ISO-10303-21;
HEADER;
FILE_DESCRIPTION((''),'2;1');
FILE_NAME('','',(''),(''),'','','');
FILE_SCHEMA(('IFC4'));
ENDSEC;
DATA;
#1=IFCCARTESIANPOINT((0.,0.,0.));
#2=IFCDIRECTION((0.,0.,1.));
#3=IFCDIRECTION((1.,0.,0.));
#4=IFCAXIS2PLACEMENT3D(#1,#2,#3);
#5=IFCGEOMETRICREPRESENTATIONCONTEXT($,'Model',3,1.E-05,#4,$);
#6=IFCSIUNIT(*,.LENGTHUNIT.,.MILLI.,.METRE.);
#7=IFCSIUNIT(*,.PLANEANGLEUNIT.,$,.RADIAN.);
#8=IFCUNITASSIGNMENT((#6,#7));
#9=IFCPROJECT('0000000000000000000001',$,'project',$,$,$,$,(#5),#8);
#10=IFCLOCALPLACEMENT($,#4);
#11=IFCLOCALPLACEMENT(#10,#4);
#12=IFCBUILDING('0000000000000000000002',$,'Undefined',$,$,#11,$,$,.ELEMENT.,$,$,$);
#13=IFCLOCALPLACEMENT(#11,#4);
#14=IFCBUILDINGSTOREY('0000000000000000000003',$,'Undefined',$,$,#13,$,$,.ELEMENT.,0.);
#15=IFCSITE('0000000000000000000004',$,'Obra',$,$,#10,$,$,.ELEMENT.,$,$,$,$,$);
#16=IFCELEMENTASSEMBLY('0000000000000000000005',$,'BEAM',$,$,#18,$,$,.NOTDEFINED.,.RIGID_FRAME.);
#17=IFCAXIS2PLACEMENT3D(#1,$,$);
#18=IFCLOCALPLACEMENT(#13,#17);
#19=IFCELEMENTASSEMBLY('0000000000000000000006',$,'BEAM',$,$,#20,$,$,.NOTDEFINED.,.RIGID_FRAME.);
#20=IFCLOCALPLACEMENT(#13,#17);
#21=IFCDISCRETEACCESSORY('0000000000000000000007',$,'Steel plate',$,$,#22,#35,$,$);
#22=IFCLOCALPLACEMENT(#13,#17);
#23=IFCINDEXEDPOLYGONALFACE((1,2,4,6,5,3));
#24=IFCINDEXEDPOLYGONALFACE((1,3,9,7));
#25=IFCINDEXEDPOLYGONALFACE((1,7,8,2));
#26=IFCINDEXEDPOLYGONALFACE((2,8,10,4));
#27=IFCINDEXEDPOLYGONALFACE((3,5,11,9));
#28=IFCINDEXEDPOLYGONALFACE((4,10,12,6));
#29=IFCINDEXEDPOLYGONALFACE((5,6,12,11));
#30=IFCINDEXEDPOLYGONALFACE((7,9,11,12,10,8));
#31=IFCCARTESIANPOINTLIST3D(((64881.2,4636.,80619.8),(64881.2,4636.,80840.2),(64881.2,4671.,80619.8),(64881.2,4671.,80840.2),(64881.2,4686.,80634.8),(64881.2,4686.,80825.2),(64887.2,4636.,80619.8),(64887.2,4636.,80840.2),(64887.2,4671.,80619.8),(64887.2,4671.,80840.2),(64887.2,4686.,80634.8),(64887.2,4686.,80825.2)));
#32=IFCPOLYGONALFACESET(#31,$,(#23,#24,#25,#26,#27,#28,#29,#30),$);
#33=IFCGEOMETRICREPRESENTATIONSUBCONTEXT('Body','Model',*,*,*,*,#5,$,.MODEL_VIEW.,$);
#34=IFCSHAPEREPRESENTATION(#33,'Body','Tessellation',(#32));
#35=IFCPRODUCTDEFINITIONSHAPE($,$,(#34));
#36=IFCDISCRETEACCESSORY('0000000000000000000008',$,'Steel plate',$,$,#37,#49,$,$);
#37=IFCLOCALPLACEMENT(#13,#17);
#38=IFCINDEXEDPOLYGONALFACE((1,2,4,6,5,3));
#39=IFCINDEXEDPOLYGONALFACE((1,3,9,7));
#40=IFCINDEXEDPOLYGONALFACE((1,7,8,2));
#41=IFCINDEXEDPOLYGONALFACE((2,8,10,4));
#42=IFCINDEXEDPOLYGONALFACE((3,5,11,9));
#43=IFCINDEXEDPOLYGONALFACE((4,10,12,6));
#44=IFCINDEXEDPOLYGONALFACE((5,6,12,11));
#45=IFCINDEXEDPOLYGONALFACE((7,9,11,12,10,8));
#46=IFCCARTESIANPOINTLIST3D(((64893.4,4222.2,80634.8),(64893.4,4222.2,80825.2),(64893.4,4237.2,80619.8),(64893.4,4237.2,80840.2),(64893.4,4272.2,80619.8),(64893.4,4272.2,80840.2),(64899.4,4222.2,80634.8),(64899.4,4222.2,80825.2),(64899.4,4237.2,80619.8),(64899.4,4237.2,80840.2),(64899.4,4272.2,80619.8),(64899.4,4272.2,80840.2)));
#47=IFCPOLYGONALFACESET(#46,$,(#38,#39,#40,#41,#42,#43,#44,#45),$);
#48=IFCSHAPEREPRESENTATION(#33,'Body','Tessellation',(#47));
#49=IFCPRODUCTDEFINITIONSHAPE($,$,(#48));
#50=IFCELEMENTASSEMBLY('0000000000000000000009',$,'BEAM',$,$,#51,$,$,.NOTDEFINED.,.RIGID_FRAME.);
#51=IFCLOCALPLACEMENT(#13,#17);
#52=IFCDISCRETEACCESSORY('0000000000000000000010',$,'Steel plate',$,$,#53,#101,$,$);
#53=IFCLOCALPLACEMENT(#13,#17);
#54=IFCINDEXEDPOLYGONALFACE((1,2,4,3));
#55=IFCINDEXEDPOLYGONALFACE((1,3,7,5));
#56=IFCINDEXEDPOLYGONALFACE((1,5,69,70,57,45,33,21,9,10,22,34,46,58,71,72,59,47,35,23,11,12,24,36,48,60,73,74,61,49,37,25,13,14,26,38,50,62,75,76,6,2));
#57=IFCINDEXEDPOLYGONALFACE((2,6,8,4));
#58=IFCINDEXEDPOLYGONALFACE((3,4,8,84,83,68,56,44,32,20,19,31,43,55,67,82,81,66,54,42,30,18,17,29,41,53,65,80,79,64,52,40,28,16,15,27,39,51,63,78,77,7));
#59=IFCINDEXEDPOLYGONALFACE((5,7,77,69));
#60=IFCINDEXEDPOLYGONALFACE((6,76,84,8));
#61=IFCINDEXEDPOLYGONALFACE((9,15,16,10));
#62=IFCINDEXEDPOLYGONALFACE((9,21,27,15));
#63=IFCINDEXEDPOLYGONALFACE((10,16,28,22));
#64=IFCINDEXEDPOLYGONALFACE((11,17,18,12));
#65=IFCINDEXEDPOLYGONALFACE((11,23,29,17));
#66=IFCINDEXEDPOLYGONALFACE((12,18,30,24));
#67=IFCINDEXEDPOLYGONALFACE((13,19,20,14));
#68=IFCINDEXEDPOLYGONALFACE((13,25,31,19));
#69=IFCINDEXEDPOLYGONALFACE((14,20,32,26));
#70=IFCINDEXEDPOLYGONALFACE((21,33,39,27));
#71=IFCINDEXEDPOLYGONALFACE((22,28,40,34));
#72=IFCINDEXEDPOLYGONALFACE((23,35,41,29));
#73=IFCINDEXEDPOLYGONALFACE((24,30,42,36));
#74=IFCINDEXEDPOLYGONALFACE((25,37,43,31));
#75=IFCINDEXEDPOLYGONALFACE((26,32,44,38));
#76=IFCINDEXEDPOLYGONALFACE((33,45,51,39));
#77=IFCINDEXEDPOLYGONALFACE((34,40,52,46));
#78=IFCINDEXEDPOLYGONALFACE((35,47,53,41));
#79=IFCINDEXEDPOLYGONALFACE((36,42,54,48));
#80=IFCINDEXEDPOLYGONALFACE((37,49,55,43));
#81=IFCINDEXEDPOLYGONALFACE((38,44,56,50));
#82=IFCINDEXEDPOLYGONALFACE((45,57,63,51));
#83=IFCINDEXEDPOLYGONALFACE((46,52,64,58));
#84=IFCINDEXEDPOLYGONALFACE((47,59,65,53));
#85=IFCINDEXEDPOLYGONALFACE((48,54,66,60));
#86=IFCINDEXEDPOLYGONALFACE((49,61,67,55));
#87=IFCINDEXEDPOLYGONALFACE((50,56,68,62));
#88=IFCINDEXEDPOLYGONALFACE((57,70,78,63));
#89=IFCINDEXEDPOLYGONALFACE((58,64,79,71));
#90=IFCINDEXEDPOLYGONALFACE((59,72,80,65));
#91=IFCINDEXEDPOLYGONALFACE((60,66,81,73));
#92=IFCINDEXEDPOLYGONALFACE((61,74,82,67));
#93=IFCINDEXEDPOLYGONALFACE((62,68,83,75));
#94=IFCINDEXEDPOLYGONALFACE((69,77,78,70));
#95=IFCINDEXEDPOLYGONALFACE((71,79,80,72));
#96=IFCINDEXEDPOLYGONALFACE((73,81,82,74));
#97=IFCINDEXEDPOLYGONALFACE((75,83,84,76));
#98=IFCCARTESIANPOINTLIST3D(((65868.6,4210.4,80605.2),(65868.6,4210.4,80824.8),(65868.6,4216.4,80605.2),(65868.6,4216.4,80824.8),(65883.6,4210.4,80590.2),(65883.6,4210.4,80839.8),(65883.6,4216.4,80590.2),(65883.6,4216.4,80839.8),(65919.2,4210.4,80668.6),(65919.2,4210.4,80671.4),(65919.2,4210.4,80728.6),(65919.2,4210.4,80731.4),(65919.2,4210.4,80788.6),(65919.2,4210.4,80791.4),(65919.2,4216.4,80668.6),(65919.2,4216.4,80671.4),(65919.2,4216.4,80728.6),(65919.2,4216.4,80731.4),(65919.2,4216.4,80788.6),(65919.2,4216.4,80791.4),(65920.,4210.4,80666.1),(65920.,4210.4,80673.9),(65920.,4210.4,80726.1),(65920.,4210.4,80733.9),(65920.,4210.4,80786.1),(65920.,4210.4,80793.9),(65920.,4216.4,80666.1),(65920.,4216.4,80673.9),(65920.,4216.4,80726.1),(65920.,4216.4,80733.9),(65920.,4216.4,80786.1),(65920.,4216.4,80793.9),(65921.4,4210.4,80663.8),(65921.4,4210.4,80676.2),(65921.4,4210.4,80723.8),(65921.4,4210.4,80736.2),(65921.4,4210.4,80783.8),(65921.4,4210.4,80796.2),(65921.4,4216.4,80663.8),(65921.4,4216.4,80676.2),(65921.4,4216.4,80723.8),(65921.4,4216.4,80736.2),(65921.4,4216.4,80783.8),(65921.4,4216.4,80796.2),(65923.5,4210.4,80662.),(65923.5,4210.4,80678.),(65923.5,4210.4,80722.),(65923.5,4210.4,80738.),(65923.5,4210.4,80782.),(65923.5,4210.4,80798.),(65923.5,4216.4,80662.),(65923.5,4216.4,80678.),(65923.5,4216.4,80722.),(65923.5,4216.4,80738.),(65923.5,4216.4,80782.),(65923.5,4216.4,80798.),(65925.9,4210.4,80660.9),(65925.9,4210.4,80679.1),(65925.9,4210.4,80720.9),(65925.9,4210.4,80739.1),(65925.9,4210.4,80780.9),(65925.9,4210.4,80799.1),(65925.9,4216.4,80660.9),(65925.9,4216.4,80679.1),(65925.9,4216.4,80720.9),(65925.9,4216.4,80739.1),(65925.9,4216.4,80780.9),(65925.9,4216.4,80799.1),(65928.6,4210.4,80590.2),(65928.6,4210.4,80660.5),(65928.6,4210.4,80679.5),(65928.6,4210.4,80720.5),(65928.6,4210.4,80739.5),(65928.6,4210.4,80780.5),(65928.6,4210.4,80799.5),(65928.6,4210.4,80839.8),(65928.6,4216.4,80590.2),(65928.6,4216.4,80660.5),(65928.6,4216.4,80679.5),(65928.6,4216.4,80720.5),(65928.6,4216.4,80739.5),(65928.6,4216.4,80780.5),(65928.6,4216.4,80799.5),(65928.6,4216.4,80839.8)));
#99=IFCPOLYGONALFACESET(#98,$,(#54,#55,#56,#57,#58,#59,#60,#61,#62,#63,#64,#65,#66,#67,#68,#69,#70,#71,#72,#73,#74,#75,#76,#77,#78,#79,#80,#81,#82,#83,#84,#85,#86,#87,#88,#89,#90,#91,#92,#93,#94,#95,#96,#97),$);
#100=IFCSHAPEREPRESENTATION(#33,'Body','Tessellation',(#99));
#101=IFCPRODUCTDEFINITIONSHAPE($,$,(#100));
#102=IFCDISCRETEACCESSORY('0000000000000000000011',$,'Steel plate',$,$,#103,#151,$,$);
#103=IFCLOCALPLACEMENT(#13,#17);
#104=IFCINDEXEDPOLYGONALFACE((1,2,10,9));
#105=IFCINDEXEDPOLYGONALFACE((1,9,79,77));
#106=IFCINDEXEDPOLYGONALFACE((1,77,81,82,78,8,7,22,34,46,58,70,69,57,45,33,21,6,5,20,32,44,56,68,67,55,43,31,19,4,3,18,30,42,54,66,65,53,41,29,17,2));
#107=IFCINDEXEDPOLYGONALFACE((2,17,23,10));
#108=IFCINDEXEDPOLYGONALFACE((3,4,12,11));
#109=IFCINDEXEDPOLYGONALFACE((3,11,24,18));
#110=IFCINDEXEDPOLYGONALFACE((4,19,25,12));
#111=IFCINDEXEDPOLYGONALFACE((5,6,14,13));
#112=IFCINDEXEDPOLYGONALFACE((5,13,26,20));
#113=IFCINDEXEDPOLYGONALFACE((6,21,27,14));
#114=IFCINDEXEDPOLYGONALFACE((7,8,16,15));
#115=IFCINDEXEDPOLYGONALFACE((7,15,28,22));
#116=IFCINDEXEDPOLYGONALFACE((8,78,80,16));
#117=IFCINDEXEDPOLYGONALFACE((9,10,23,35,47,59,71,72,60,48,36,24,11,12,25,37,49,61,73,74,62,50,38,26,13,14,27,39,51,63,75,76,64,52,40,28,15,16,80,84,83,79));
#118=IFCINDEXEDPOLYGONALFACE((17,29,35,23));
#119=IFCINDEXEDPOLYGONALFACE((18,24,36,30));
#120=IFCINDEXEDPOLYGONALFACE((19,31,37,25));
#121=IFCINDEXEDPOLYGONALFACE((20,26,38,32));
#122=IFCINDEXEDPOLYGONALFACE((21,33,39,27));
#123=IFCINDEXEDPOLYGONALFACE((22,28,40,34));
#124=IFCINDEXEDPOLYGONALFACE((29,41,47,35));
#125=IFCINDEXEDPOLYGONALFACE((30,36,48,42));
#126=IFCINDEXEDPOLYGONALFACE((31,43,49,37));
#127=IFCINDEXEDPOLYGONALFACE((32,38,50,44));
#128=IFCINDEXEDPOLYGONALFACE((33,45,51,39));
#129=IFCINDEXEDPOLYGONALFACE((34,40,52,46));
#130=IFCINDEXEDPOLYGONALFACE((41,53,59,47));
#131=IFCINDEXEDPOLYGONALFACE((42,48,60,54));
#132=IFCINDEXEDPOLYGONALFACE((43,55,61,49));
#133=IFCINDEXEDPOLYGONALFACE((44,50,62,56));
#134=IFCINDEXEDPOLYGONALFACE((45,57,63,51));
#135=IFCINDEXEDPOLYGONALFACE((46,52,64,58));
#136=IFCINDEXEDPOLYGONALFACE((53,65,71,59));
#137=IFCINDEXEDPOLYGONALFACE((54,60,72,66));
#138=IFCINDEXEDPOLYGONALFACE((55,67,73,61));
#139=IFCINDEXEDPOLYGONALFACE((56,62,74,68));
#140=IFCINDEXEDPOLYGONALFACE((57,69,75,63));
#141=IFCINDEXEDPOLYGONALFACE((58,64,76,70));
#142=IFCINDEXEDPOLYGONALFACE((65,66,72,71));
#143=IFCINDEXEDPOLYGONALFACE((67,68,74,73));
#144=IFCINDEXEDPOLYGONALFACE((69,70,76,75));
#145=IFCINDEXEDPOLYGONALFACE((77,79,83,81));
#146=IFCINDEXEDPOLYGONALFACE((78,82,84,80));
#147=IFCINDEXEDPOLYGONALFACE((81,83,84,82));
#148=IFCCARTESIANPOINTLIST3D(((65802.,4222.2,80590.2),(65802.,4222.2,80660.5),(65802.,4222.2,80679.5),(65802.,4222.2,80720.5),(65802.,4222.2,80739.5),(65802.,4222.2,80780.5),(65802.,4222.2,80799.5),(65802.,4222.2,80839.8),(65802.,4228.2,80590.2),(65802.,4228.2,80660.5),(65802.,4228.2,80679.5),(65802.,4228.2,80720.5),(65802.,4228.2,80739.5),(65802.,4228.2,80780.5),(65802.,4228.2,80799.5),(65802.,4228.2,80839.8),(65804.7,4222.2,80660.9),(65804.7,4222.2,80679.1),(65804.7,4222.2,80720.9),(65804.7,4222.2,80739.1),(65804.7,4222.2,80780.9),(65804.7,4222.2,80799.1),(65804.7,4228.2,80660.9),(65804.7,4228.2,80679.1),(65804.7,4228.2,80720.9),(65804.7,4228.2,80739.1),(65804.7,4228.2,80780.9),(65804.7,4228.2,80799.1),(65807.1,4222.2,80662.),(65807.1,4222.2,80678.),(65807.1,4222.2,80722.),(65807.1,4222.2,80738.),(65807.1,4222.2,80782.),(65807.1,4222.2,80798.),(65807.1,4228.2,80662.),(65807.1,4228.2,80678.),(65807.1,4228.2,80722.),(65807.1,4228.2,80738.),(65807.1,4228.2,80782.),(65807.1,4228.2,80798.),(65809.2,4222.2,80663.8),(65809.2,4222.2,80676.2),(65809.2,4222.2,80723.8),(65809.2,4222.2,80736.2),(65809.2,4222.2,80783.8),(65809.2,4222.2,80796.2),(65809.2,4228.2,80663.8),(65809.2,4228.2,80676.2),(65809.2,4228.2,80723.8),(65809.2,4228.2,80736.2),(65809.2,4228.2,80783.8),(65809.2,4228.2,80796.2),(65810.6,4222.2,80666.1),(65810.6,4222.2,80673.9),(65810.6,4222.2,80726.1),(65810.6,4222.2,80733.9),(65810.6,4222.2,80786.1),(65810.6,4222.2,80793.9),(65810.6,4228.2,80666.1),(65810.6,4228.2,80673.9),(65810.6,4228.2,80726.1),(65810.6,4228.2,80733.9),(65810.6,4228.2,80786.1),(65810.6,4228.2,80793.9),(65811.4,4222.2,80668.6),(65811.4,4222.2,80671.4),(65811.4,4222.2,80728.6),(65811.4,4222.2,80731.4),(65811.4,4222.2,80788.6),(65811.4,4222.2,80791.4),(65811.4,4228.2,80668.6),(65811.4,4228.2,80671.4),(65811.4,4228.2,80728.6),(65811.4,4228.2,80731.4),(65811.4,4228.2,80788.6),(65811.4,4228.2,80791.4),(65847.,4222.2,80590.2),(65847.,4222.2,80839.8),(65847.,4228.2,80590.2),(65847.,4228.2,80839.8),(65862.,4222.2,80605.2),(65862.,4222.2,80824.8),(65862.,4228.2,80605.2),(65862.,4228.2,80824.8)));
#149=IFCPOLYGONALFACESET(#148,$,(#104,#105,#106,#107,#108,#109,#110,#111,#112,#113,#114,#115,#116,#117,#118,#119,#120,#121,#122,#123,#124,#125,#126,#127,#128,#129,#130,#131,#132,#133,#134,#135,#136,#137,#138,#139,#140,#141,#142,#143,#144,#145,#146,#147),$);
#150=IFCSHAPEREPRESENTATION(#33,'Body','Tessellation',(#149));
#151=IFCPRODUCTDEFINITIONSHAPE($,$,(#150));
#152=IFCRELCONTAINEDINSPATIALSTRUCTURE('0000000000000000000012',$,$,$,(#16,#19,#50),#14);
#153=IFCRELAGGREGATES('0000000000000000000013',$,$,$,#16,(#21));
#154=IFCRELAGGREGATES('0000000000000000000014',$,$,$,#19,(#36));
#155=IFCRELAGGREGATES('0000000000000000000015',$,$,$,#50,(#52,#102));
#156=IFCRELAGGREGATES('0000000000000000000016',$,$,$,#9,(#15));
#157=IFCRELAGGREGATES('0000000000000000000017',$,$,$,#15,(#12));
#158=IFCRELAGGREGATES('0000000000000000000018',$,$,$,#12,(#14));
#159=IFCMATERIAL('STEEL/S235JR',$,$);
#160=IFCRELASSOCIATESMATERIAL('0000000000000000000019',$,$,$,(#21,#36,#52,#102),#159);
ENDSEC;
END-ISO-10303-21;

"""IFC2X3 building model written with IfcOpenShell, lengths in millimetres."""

from ifc_helpers import new_model, si_unit, frame, origin_with_axes, origin_2d_with_axis, place, context, subcontext, project, spatial, polyline, circle, outline, extrude, source, transform, mapped, material, element, aggregate, save


model = new_model("IFC2X3")

# Units and contexts
model_context = context("Model", 3, precision=1e-05, world=origin_with_axes())
body_context = subcontext(model_context, "Body", "Model", "MODEL_VIEW")
ifc_project = project(units=[si_unit("LENGTHUNIT", "METRE", prefix="MILLI"), si_unit("PLANEANGLEUNIT", "RADIAN")], contexts=[model_context])

# Site, building, storey
site_placement = place(None, origin_with_axes())
site = spatial("IfcSite", under=ifc_project, at=site_placement, Name="Obra", CompositionType="ELEMENT")
building_placement = place(site_placement, origin_with_axes())
building = spatial("IfcBuilding", under=site, at=building_placement, Name="Undefined", CompositionType="ELEMENT")
storey_placement = place(building_placement, origin_with_axes())
storey = spatial("IfcBuildingStorey", under=building, at=storey_placement, Name="Undefined", CompositionType="ELEMENT", Elevation=0.0)

# Element assemblies
ifc_material = material(Name="STEEL/S235JR")
assembly_1_placement = place(storey_placement, origin_with_axes())
assembly_1 = element("IfcElementAssembly", 1, at=assembly_1_placement, inside=storey, Name="BEAM", AssemblyPlace="NOTDEFINED", PredefinedType="RIGID_FRAME")
assembly_2_placement = place(storey_placement, origin_with_axes())
assembly_2 = element("IfcElementAssembly", 2, at=assembly_2_placement, inside=storey, Name="BEAM", AssemblyPlace="NOTDEFINED", PredefinedType="RIGID_FRAME")

# Discrete accessories
discrete_accessory_1_placement = place(assembly_1_placement, frame((64884.2, 4636.0, 80619.8), z_axis=(1.0, 0.0, 0.0), x_axis=(0.0, 1.0, 0.0)))
discrete_accessory_1 = element("IfcDiscreteAccessory", 3, at=discrete_accessory_1_placement, material=ifc_material, Name="Steel plate", context=body_context, shape_type="SweptSolid", body=[
    extrude(outline(polyline([(0.0, 0.0), (35.0, 0.0), (50.0, 15.0), (50.0, 205.4), (35.0, 220.4), (0.0, 220.4), (0.0, 0.0)])), frame((0.0, 0.0, -3.0), z_axis=(0.0, 0.0, 1.0), x_axis=(1.0, 0.0, 0.0)), (0.0, 0.0, 1.0), 6.0),
])
aggregate(assembly_1, [discrete_accessory_1])
discrete_accessory_2_placement = place(assembly_2_placement, frame((64896.4, 4272.2, 80619.8), z_axis=(-1.0, 0.0, 0.0), x_axis=(0.0, -1.0, 0.0)))
discrete_accessory_2 = element("IfcDiscreteAccessory", 4, at=discrete_accessory_2_placement, material=ifc_material, Name="Steel plate", context=body_context, shape_type="SweptSolid", body=[
    extrude(outline(polyline([(0.0, 0.0), (35.0, 0.0), (50.0, 15.0), (50.0, 205.4), (35.0, 220.4), (0.0, 220.4), (0.0, 0.0)])), frame((0.0, 0.0, -3.0), z_axis=(0.0, 0.0, 1.0), x_axis=(1.0, 0.0, 0.0)), (0.0, 0.0, 1.0), 6.0),
])
aggregate(assembly_2, [discrete_accessory_2])

# Element assembly, discrete accessories, openings
assembly_3_placement = place(storey_placement, origin_with_axes())
assembly_3 = element("IfcElementAssembly", 5, at=assembly_3_placement, inside=storey, Name="BEAM", AssemblyPlace="NOTDEFINED", PredefinedType="RIGID_FRAME")
discrete_accessory_3_placement = place(assembly_3_placement, frame((65928.6, 4213.4, 80590.2), z_axis=(0.0, 1.0, 0.0), x_axis=(-1.0, 0.0, 0.0)))
discrete_accessory_3 = element("IfcDiscreteAccessory", 6, at=discrete_accessory_3_placement, material=ifc_material, Name="Steel plate", context=body_context, shape_type="SweptSolid", body=[
    extrude(outline(polyline([(0.0, 0.0), (45.0, 0.0), (60.0, 15.0), (60.0, 234.6), (45.0, 249.6), (0.0, 249.6), (0.0, 0.0)])), frame((0.0, 0.0, -3.0), z_axis=(0.0, 0.0, 1.0), x_axis=(1.0, 0.0, 0.0)), (0.0, 0.0, 1.0), 6.0),
])
shared_shape_1 = source(origin_with_axes(), body_context, "Body", "SweptSolid", [
    extrude(circle(Radius=9.5, at=origin_2d_with_axis()), frame((0.0, -9.2, 0.0), z_axis=(0.0, 1.0, 0.0), x_axis=(1.0, 0.0, 0.0)), (0.0, 0.0, 1.0), 6.2),
])
opening_1_placement = place(assembly_3_placement, frame((65878.6, 4219.5, 80850.0), z_axis=(1.0, 0.0, 0.0), x_axis=(0.0, 0.0, -1.0)))
element("IfcOpeningElement", 7, at=opening_1_placement, cuts=discrete_accessory_3, ObjectType="Opening", context=body_context, shape_type="MappedRepresentation", body=[
    mapped(shared_shape_1, transform((60.0, 0.0, 50.0))),
    mapped(shared_shape_1, transform((120.0, 0.0, 50.0))),
    mapped(shared_shape_1, transform((180.0, 0.0, 50.0))),
])
discrete_accessory_4_placement = place(assembly_3_placement, frame((65802.0, 4225.2, 80590.2), z_axis=(0.0, -1.0, 0.0), x_axis=(1.0, 0.0, 0.0)))
discrete_accessory_4 = element("IfcDiscreteAccessory", 8, at=discrete_accessory_4_placement, material=ifc_material, Name="Steel plate", context=body_context, shape_type="SweptSolid", body=[
    extrude(outline(polyline([(0.0, 0.0), (45.0, 0.0), (60.0, 15.0), (60.0, 234.6), (45.0, 249.6), (0.0, 249.6), (0.0, 0.0)])), frame((0.0, 0.0, -3.0), z_axis=(0.0, 0.0, 1.0), x_axis=(1.0, 0.0, 0.0)), (0.0, 0.0, 1.0), 6.0),
])
opening_2_placement = place(assembly_3_placement, frame((65852.0, 4219.1, 80850.0), z_axis=(-1.0, 0.0, 0.0), x_axis=(0.0, 0.0, -1.0)))
element("IfcOpeningElement", 9, at=opening_2_placement, cuts=discrete_accessory_4, ObjectType="Opening", context=body_context, shape_type="MappedRepresentation", body=[
    mapped(shared_shape_1, transform((60.0, 0.0, 50.0))),
    mapped(shared_shape_1, transform((120.0, 0.0, 50.0))),
    mapped(shared_shape_1, transform((180.0, 0.0, 50.0))),
])
aggregate(assembly_3, [discrete_accessory_3, discrete_accessory_4])

save(model, "model.ifc")
